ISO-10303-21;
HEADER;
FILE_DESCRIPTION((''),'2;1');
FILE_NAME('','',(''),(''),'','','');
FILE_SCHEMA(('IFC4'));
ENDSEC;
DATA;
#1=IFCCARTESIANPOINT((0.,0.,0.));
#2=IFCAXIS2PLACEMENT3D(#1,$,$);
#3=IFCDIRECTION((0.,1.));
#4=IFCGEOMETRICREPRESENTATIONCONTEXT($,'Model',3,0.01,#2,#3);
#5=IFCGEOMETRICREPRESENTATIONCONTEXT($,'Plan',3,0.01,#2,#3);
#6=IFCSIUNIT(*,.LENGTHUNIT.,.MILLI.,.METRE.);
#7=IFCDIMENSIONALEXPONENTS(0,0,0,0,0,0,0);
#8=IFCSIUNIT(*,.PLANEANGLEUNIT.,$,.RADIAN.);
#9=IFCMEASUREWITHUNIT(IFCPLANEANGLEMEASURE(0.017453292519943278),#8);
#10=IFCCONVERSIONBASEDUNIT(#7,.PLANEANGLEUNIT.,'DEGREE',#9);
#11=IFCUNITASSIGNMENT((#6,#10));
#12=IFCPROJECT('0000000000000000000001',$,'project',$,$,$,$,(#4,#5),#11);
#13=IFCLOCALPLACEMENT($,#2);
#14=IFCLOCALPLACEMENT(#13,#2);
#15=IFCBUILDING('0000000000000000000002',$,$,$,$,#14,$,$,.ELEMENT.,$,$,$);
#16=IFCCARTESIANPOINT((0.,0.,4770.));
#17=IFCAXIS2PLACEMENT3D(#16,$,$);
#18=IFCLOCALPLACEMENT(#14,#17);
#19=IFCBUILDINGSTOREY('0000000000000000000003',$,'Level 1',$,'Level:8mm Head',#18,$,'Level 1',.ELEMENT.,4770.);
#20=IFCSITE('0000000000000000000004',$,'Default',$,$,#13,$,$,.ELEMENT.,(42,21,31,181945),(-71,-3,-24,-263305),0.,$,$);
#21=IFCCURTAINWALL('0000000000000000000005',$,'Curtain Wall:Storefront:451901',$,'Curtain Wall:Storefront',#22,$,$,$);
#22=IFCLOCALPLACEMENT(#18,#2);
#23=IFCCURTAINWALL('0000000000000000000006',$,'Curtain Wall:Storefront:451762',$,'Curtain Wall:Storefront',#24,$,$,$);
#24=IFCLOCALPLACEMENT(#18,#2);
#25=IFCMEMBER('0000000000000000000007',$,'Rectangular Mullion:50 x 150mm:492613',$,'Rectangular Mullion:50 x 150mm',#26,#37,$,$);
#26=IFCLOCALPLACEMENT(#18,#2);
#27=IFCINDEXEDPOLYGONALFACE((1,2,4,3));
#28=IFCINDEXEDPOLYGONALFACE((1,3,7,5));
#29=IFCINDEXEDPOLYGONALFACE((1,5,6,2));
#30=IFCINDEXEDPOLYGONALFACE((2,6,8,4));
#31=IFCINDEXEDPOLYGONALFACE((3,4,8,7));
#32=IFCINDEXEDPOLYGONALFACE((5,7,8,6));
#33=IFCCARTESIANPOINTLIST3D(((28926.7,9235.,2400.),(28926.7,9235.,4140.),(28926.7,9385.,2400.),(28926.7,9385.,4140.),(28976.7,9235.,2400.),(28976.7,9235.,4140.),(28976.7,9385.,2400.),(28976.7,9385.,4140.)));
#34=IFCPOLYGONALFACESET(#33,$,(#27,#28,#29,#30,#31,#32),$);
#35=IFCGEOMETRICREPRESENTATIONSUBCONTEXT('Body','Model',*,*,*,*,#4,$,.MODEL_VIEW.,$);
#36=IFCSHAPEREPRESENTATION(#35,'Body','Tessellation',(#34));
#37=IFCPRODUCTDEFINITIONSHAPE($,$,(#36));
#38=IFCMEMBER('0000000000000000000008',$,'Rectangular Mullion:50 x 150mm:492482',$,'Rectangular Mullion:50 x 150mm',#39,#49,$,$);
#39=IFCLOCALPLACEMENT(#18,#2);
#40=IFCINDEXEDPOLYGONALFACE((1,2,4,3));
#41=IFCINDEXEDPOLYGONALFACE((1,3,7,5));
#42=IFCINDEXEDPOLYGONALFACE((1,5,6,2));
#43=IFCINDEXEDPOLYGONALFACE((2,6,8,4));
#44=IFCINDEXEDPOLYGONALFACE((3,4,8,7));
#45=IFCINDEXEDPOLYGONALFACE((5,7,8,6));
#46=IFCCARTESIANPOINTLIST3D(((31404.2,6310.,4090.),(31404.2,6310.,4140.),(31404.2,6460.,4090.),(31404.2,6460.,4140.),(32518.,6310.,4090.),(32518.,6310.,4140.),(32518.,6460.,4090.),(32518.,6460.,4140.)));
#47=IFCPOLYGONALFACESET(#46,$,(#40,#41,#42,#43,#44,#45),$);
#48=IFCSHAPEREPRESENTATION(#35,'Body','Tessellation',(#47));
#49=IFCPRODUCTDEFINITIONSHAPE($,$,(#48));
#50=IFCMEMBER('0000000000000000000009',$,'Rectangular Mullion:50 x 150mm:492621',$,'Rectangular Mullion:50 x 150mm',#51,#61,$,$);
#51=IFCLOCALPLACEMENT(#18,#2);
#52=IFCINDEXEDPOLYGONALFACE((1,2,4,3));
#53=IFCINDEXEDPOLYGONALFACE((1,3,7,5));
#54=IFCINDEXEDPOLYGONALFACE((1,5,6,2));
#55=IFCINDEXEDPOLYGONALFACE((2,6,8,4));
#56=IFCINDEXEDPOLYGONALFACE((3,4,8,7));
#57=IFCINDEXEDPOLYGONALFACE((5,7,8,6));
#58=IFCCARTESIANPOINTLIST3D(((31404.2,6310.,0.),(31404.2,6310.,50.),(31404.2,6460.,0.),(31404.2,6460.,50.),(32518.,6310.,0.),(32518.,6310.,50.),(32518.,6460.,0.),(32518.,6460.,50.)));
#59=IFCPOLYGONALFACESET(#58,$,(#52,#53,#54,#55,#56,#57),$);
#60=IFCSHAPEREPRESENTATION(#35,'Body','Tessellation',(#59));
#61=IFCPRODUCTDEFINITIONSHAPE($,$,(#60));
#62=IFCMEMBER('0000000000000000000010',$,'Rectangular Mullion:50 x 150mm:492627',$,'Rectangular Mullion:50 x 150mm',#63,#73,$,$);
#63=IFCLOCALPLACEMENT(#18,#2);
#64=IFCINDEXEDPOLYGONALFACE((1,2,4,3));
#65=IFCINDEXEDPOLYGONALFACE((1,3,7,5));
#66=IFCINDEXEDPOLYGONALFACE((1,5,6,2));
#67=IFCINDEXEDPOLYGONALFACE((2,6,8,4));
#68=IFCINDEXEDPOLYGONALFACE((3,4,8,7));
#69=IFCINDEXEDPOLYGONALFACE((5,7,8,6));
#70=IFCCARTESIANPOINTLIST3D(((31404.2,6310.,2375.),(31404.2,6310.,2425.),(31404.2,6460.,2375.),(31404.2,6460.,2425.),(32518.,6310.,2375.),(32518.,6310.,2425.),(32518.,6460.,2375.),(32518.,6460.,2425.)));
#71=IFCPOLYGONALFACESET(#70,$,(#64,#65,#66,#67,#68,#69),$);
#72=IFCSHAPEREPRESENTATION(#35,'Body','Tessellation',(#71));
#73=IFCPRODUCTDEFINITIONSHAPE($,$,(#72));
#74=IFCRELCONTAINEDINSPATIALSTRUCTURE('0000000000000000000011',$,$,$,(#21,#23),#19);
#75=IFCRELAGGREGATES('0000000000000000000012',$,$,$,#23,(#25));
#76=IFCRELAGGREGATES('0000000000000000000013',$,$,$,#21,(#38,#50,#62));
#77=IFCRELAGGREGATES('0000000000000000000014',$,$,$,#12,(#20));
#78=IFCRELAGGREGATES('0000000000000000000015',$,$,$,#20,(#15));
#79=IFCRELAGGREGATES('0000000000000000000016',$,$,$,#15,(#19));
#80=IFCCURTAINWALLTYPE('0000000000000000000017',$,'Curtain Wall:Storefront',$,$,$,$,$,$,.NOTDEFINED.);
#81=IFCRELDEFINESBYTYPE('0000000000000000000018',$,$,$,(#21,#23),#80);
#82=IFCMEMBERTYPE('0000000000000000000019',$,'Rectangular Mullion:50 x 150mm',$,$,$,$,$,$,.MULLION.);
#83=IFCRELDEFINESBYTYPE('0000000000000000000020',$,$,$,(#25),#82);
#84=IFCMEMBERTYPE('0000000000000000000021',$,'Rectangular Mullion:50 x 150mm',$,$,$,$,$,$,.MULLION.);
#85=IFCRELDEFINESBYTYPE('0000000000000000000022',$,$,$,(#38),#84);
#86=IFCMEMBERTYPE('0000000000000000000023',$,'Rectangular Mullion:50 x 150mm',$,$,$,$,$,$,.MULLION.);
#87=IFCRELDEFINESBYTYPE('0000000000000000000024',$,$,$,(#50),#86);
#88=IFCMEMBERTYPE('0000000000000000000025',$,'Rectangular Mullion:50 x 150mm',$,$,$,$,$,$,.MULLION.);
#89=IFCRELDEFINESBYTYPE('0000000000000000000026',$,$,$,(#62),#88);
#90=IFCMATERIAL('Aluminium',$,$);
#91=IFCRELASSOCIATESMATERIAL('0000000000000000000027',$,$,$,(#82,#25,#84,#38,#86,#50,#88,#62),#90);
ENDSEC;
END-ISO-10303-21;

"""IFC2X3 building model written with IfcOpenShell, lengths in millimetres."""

from ifc_helpers import new_model, entity, si_unit, converted_unit, direction, frame, origin, origin_2d_with_axis, place, context, subcontext, project, spatial, rectangle, extrude, source, transform, mapped, material, type_object, type_shapes, element, aggregate, save


model = new_model("IFC2X3")

# Units and contexts
model_context = context("Model", 3, precision=0.01, world=origin(), true_north=direction((0.0, 1.0)))
plan_context = context("Plan", 3, precision=0.01, world=origin(), true_north=direction((0.0, 1.0)))
body_context = subcontext(model_context, "Body", "Model", "MODEL_VIEW")
ifc_project = project(units=[si_unit("LENGTHUNIT", "METRE", prefix="MILLI"), converted_unit("PLANEANGLEUNIT", "DEGREE", entity("IfcPlaneAngleMeasure", 0.017453292519943278), si_unit("PLANEANGLEUNIT", "RADIAN"), dimensions=[0, 0, 0, 0, 0, 0, 0])], contexts=[model_context, plan_context])

# Site, building, storey
site_placement = place(None, origin())
site = spatial("IfcSite", under=ifc_project, at=site_placement, Name="Default", CompositionType="ELEMENT", RefLatitude=(42, 21, 31, 181945), RefLongitude=(-71, -3, -24, -263305), RefElevation=0.0)
building_placement = place(site_placement, origin())
building = spatial("IfcBuilding", under=site, at=building_placement, CompositionType="ELEMENT")
storey_placement = place(building_placement, frame((0.0, 0.0, 4770.0)))
storey = spatial("IfcBuildingStorey", under=building, at=storey_placement, Name="Level 1", ObjectType="Level:8mm Head", LongName="Level 1", CompositionType="ELEMENT", Elevation=4770.0)

# Curtain walls, member
curtain_wall_type = type_object("IfcCurtainWallType", Name="Curtain Wall:Storefront", PredefinedType="NOTDEFINED")
curtain_wall_1_placement = place(storey_placement, frame((0.0, 0.0, -4770.0)))
curtain_wall_1 = element("IfcCurtainWall", 1, at=curtain_wall_1_placement, inside=storey, type_object=curtain_wall_type, Name="Curtain Wall:Storefront:451901", ObjectType="Curtain Wall:Storefront")
ifc_material_1 = material(Name="Aluminium")
curtain_wall_2_placement = place(storey_placement, frame((0.0, 0.0, -4770.0)))
curtain_wall_2 = element("IfcCurtainWall", 2, at=curtain_wall_2_placement, inside=storey, type_object=curtain_wall_type, Name="Curtain Wall:Storefront:451762", ObjectType="Curtain Wall:Storefront")
member_type_1 = type_object("IfcMemberType", Name="Rectangular Mullion:50 x 150mm", PredefinedType="MULLION", material=ifc_material_1)
shared_shape_1 = source(origin(), body_context, "Body", "SweptSolid", [
    extrude(rectangle(XDim=50.0, YDim=150.0, at=origin_2d_with_axis()), frame((0.0, 0.0, -1740.0), z_axis=(0.0, 0.0, 1.0), x_axis=(-1.0, 0.0, 0.0)), (0.0, 0.0, 1.0), 1740.0),
])
type_shapes(member_type_1, [shared_shape_1])
member_1_placement = place(curtain_wall_2_placement, frame((28951.7, 9310.0, 7170.0), z_axis=(0.0, 0.0, -1.0), x_axis=(1.0, 0.0, 0.0)))
member_1 = element("IfcMember", 3, at=member_1_placement, type_object=member_type_1, material=ifc_material_1, Name="Rectangular Mullion:50 x 150mm:492613", ObjectType="Rectangular Mullion:50 x 150mm", context=body_context, shape_type="MappedRepresentation", body=[
    mapped(shared_shape_1, transform((0.0, 0.0, 0.0), scale=1.0)),
])

# Members
member_type_2 = type_object("IfcMemberType", Name="Rectangular Mullion:50 x 150mm", PredefinedType="MULLION", material=ifc_material_1)
shared_shape_2 = source(origin(), body_context, "Body", "SweptSolid", [
    extrude(rectangle(XDim=50.0, YDim=150.0, at=origin_2d_with_axis()), frame((-25.0, 0.0, -1113.8), z_axis=(0.0, 0.0, 1.0), x_axis=(-1.0, 0.0, 0.0)), (0.0, 0.0, 1.0), 1113.8),
])
type_shapes(member_type_2, [shared_shape_2])
member_2_placement = place(curtain_wall_1_placement, frame((32518.0, 6385.0, 8910.0), z_axis=(1.0, 0.0, 0.0), x_axis=(0.0, 0.0, 1.0)))
member_2 = element("IfcMember", 4, at=member_2_placement, type_object=member_type_2, material=ifc_material_1, Name="Rectangular Mullion:50 x 150mm:492482", ObjectType="Rectangular Mullion:50 x 150mm", context=body_context, shape_type="MappedRepresentation", body=[
    mapped(shared_shape_2, transform((0.0, 0.0, 0.0), scale=1.0)),
])
member_type_3 = type_object("IfcMemberType", Name="Rectangular Mullion:50 x 150mm", PredefinedType="MULLION", material=ifc_material_1)
shared_shape_3 = source(origin(), body_context, "Body", "SweptSolid", [
    extrude(rectangle(XDim=50.0, YDim=150.0, at=origin_2d_with_axis()), frame((-25.0, 0.0, -1113.8), z_axis=(0.0, 0.0, 1.0), x_axis=(-1.0, 0.0, 0.0)), (0.0, 0.0, 1.0), 1113.8),
])
type_shapes(member_type_3, [shared_shape_3])
member_3_placement = place(curtain_wall_1_placement, frame((31404.2, 6385.0, 4770.0), z_axis=(-1.0, 0.0, 0.0), x_axis=(0.0, 0.0, -1.0)))
member_3 = element("IfcMember", 5, at=member_3_placement, type_object=member_type_3, material=ifc_material_1, Name="Rectangular Mullion:50 x 150mm:492621", ObjectType="Rectangular Mullion:50 x 150mm", context=body_context, shape_type="MappedRepresentation", body=[
    mapped(shared_shape_3, transform((0.0, 0.0, 0.0), scale=1.0)),
])
member_type_4 = type_object("IfcMemberType", Name="Rectangular Mullion:50 x 150mm", PredefinedType="MULLION", material=ifc_material_1)
shared_shape_4 = source(origin(), body_context, "Body", "SweptSolid", [
    extrude(rectangle(XDim=50.0, YDim=150.0, at=origin_2d_with_axis()), frame((0.0, 0.0, -1113.8), z_axis=(0.0, 0.0, 1.0), x_axis=(-1.0, 0.0, 0.0)), (0.0, 0.0, 1.0), 1113.8),
])
type_shapes(member_type_4, [shared_shape_4])
member_4_placement = place(curtain_wall_1_placement, frame((32518.0, 6385.0, 7170.0), z_axis=(1.0, 0.0, 0.0), x_axis=(0.0, 0.0, 1.0)))
member_4 = element("IfcMember", 6, at=member_4_placement, type_object=member_type_4, material=ifc_material_1, Name="Rectangular Mullion:50 x 150mm:492627", ObjectType="Rectangular Mullion:50 x 150mm", context=body_context, shape_type="MappedRepresentation", body=[
    mapped(shared_shape_4, transform((0.0, 0.0, 0.0), scale=1.0)),
])

aggregate(curtain_wall_2, [member_1])
aggregate(curtain_wall_1, [member_2, member_3, member_4])

save(model, "model.ifc")
